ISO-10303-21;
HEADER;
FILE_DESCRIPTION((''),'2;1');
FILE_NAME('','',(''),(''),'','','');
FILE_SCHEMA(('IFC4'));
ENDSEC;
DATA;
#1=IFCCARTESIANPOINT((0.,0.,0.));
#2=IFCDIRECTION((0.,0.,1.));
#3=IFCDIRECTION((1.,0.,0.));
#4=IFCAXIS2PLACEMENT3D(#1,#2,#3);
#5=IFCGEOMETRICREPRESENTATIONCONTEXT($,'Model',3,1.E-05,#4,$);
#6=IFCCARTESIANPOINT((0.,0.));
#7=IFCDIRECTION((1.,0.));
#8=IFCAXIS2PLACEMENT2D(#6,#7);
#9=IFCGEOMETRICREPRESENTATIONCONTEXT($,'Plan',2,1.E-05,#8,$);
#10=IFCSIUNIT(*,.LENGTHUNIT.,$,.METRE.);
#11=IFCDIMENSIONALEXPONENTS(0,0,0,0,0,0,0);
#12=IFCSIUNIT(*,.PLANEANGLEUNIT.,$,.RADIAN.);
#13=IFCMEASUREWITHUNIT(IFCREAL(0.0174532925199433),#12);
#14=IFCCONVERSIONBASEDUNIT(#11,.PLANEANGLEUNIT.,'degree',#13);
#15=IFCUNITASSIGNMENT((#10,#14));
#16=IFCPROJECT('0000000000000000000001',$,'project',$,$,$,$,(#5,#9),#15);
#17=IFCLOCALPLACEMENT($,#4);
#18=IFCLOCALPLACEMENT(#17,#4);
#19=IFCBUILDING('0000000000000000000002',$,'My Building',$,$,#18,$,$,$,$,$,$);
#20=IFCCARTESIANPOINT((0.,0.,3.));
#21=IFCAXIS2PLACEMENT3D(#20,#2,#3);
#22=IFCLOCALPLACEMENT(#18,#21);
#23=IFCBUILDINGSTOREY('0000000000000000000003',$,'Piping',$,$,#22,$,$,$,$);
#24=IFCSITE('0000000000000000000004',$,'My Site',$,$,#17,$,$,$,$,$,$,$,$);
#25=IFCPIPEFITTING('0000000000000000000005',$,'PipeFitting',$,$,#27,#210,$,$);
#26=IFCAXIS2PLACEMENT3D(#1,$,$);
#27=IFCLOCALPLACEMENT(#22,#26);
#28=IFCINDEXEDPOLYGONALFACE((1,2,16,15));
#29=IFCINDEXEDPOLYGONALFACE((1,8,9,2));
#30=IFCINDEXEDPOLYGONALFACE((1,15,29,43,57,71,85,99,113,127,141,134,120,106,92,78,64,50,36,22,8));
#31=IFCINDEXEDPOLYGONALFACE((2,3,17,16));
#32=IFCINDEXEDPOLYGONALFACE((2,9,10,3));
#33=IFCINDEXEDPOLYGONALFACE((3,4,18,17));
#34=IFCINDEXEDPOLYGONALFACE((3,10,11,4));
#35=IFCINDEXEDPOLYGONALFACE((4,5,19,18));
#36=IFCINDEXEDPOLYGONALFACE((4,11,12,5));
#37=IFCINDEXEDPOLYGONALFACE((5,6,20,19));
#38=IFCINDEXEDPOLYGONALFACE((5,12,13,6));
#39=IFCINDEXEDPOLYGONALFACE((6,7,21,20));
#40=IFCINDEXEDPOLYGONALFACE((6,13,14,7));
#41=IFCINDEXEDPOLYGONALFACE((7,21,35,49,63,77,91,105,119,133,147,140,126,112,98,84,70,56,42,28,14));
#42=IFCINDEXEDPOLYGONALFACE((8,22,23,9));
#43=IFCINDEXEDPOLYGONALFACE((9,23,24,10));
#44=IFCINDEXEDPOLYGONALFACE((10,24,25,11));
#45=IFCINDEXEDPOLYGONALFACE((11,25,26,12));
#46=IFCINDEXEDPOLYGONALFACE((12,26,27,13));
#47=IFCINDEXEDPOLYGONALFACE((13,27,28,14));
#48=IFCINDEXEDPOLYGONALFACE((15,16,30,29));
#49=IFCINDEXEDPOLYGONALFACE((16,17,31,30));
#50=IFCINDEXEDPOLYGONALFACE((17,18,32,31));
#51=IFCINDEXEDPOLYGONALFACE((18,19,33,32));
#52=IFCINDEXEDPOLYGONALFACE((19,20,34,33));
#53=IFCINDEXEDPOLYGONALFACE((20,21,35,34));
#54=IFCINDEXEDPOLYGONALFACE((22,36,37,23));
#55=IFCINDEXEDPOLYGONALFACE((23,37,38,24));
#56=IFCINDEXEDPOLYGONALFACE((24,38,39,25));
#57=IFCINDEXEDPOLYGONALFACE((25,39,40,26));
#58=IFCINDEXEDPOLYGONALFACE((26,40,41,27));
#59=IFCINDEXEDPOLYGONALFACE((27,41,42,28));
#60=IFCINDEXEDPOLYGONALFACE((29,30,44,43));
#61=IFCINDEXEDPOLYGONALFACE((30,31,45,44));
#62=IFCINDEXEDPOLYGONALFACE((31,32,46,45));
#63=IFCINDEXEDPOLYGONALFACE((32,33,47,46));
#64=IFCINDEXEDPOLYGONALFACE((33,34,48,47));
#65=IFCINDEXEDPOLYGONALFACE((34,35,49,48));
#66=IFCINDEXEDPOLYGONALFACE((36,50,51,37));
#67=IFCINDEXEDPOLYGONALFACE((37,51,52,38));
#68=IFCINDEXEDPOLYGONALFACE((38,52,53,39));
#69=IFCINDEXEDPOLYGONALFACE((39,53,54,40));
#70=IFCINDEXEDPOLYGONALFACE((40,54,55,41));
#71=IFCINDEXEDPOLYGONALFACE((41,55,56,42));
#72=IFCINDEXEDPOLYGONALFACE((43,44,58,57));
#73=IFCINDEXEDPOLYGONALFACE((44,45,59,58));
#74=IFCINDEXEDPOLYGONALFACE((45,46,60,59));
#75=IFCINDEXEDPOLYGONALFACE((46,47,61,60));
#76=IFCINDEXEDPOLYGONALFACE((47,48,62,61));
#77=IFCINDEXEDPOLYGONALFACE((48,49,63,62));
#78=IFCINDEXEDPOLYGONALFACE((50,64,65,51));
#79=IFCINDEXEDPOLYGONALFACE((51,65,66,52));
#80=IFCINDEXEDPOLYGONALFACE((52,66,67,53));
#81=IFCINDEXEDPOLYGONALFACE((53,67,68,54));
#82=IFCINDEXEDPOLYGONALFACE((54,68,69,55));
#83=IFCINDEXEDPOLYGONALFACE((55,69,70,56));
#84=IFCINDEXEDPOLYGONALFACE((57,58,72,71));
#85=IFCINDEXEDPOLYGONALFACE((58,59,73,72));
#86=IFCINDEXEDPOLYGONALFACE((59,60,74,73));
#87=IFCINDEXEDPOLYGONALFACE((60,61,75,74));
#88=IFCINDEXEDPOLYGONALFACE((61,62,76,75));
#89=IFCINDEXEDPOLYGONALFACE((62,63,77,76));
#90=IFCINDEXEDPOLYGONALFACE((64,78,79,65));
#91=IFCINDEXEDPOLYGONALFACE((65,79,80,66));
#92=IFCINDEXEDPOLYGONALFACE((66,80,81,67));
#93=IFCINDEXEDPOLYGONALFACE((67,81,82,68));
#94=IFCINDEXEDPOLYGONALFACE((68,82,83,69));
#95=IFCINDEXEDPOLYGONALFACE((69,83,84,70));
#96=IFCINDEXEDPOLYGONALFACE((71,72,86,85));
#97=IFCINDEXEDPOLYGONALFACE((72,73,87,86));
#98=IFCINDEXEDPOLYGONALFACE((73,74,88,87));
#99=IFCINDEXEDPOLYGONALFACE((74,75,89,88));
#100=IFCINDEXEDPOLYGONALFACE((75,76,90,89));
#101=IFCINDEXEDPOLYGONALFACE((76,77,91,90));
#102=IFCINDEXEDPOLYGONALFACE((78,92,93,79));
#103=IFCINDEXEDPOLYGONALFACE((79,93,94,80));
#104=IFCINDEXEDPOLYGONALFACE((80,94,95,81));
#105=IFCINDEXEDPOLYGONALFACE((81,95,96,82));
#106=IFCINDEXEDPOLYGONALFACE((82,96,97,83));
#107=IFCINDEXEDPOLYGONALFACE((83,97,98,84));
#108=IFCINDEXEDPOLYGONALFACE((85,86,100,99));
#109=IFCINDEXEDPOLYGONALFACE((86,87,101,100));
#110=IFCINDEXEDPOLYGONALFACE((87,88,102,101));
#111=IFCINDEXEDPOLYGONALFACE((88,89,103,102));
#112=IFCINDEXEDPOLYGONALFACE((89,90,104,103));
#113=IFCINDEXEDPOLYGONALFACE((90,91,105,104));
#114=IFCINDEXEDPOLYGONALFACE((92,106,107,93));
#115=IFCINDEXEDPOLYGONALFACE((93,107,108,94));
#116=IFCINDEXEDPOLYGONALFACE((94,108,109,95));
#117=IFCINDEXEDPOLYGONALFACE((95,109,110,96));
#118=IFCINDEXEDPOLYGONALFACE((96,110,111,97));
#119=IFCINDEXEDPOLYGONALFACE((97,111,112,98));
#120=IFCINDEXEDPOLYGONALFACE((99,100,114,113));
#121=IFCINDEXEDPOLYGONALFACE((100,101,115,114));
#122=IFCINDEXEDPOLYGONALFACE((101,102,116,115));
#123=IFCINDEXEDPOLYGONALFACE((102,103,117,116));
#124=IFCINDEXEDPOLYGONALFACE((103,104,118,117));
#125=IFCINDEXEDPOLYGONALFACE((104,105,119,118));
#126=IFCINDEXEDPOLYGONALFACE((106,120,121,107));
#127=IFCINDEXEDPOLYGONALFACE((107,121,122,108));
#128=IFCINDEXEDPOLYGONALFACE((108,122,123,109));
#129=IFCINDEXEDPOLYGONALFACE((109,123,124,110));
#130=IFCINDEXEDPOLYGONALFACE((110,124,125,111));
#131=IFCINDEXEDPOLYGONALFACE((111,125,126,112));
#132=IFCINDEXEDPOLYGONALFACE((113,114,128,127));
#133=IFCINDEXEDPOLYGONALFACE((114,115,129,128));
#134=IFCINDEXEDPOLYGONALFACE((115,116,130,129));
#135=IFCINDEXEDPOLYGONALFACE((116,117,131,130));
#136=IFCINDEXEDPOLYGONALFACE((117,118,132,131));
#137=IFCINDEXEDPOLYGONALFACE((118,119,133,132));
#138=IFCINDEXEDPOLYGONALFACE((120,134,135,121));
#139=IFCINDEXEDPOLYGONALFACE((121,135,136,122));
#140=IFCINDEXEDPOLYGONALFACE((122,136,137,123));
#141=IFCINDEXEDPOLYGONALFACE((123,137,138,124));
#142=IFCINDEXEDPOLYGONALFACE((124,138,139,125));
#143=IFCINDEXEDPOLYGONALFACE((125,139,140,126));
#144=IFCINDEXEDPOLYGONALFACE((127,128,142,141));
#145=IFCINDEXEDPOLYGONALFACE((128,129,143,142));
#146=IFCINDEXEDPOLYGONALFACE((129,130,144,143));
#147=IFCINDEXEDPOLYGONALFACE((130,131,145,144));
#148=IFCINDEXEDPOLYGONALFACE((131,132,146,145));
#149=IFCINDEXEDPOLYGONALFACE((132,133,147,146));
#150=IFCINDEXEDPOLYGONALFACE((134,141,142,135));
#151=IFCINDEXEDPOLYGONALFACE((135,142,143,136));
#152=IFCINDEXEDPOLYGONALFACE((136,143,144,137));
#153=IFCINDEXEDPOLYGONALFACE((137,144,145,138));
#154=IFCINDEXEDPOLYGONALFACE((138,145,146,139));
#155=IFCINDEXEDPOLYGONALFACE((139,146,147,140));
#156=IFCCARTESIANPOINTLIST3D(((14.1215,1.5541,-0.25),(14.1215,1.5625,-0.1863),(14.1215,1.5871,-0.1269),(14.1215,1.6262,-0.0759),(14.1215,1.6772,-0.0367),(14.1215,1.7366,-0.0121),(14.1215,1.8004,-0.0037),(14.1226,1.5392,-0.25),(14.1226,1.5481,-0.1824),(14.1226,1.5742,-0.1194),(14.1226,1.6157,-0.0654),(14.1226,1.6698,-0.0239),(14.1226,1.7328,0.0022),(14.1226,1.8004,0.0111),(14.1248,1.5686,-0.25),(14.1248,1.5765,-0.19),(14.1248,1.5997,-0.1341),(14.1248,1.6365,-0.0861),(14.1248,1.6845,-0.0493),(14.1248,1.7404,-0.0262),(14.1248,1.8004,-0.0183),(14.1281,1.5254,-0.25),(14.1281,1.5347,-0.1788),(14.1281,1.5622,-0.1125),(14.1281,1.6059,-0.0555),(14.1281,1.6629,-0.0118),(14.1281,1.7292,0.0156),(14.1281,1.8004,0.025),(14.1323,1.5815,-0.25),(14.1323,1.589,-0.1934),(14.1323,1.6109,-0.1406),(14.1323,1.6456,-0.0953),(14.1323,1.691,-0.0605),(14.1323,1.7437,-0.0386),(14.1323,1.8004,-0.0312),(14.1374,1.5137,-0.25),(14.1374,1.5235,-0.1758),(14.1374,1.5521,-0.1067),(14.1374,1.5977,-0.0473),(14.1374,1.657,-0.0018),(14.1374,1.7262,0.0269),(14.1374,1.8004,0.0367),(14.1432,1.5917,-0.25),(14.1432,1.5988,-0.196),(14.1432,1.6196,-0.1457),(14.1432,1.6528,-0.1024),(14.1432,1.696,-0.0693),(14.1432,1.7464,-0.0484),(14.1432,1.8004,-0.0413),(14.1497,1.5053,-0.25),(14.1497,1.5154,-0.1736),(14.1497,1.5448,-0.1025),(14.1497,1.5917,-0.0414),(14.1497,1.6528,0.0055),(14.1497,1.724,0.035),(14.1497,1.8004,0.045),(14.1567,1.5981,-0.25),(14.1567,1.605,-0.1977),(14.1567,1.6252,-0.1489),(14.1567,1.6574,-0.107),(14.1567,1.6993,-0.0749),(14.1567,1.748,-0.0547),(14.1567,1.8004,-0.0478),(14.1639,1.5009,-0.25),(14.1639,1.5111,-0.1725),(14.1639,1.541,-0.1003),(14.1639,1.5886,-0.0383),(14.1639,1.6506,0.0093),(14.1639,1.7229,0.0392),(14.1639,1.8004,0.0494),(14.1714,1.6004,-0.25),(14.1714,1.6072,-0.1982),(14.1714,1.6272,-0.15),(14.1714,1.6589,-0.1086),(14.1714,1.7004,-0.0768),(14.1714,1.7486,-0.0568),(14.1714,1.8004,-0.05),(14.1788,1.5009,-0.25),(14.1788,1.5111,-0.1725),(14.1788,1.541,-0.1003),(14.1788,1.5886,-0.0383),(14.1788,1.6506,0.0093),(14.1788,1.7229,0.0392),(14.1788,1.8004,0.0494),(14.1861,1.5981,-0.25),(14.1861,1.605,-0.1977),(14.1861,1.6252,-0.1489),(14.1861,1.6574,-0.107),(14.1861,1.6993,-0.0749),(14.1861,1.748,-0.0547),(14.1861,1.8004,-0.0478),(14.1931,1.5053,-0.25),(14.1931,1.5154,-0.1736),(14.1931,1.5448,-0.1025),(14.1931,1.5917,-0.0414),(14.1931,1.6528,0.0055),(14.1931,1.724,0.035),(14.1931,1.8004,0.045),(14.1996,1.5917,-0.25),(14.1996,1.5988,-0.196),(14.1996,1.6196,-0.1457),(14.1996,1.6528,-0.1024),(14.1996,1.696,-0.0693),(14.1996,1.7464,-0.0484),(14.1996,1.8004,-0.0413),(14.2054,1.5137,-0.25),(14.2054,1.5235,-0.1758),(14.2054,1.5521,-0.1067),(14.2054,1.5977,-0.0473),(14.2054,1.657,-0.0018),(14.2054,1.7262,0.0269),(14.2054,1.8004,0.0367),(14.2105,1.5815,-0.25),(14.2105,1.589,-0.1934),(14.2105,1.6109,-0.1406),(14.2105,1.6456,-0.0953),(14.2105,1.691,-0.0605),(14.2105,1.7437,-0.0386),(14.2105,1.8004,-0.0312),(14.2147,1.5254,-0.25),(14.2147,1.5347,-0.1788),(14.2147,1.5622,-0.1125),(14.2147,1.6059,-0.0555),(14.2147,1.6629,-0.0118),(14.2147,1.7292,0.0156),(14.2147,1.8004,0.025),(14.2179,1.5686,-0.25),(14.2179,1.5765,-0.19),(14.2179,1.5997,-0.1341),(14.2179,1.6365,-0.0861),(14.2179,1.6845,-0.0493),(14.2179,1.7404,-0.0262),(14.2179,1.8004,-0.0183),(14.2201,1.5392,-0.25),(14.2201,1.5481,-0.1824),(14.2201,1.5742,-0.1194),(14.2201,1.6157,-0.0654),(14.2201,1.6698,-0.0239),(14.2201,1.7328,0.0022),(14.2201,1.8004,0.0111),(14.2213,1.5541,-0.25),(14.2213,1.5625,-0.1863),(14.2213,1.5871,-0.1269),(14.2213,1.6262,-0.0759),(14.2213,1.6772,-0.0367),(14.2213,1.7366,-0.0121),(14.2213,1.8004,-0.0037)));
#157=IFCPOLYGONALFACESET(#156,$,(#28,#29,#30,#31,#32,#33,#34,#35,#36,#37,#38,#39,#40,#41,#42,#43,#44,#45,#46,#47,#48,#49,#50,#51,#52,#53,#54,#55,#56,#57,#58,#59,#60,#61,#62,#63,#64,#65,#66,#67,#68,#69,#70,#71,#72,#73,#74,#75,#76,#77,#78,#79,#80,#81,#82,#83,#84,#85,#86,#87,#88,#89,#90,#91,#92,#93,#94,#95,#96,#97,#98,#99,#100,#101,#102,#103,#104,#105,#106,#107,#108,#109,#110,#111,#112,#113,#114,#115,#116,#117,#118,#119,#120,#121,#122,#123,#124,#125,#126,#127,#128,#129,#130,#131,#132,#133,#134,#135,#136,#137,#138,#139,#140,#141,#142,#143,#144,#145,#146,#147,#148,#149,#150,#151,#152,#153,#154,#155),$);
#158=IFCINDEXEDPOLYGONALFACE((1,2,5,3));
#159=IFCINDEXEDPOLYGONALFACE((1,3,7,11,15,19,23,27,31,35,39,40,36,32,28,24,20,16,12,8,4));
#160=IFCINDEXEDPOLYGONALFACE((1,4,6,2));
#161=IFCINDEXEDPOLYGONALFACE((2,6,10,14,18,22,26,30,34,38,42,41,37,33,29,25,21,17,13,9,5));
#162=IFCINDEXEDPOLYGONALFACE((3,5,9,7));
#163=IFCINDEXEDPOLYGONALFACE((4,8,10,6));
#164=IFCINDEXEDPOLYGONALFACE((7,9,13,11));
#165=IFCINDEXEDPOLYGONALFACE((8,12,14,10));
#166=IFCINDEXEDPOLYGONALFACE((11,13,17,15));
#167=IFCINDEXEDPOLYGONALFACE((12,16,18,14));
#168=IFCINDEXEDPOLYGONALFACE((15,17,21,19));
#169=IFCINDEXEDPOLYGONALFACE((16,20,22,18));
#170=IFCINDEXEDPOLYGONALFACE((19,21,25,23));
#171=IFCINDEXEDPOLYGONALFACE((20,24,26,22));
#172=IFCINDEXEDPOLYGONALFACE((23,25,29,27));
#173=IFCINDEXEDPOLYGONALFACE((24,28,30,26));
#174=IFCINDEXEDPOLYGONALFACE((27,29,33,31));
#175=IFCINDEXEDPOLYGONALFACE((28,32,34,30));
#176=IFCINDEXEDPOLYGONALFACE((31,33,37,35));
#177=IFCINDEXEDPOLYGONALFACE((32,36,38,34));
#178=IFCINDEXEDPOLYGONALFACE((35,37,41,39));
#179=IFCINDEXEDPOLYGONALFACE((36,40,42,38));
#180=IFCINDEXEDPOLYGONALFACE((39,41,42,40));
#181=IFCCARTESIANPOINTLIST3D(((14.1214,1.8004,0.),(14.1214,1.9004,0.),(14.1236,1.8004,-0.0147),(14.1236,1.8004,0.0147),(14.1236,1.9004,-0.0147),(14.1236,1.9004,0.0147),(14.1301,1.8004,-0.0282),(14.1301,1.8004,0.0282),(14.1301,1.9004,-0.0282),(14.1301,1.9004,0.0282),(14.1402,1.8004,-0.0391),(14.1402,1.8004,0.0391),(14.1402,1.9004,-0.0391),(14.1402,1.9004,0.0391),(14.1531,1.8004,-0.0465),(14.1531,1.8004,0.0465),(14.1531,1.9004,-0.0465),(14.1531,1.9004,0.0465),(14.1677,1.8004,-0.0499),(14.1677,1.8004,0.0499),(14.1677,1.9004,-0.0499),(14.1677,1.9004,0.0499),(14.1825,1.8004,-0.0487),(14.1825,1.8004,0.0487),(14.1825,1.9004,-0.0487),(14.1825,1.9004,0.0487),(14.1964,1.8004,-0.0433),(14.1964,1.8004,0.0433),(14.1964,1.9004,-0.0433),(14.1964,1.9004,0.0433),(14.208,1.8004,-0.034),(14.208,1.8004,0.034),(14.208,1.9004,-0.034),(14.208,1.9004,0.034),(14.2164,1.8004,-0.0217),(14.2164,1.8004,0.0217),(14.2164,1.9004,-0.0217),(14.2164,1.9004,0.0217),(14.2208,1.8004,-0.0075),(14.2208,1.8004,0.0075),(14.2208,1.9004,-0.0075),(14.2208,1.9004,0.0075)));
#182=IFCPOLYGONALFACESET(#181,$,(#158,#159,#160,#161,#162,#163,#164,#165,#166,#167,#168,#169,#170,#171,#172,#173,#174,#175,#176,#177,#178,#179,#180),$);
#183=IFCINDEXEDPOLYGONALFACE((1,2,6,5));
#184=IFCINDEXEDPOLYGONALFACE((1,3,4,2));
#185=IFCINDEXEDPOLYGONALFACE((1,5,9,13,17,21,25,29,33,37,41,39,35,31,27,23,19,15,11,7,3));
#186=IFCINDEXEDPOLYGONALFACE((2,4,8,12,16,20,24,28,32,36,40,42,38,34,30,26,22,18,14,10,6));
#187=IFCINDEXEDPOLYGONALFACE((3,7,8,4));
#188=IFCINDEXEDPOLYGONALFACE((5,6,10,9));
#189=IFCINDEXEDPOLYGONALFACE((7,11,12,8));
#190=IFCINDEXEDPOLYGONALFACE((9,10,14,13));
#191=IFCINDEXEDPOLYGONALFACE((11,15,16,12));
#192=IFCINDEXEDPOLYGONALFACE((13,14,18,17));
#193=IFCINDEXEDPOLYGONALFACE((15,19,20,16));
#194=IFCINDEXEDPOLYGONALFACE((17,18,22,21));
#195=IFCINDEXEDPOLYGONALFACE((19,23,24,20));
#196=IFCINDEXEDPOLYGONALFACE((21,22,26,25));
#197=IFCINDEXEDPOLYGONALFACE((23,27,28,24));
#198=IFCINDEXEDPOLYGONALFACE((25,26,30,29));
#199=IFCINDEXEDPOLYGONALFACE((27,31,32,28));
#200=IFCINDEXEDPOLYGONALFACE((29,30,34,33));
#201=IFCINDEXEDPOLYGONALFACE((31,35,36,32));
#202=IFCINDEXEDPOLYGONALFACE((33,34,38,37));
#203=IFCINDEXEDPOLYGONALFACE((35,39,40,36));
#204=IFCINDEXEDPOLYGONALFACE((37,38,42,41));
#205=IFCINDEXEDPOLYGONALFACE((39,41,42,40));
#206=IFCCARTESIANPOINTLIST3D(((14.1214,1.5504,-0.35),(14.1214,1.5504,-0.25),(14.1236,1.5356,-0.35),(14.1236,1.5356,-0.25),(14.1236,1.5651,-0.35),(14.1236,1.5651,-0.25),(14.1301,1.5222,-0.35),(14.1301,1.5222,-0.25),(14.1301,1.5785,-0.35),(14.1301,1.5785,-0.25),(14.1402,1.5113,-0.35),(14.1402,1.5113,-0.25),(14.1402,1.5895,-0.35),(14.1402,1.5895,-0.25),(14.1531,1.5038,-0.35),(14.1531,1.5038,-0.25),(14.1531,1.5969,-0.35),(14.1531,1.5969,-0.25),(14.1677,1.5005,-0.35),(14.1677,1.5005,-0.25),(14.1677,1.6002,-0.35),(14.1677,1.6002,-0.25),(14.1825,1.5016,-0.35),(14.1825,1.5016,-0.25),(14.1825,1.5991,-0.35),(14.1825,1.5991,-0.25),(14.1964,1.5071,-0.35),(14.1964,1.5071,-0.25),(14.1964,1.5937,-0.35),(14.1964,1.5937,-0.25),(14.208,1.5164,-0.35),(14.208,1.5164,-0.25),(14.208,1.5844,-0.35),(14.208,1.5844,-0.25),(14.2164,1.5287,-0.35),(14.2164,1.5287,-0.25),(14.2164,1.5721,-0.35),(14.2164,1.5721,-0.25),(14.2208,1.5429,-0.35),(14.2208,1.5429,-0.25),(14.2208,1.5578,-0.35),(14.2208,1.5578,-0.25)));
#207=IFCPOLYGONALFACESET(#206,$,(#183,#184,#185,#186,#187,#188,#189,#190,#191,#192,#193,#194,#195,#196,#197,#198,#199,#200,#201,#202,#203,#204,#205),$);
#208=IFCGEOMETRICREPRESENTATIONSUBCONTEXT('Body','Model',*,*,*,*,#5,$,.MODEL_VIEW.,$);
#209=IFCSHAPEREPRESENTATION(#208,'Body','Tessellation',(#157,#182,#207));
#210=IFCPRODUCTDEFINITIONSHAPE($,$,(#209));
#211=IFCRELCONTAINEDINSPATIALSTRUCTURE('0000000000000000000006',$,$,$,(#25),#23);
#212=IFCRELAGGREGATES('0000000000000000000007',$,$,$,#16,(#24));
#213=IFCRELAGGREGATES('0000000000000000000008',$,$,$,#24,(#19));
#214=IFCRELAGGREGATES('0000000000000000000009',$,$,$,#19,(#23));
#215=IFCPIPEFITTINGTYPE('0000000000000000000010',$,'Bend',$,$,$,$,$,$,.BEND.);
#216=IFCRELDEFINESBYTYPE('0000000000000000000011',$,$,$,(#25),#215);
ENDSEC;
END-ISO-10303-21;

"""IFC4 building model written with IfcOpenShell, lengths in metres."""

from ifc_helpers import new_model, entity, si_unit, converted_unit, frame, origin_with_axes, origin_2d_with_axis, place, context, subcontext, project, spatial, circle, extrude, source, transform, mapped, type_object, type_shapes, element, save


model = new_model("IFC4")

# Units and contexts
model_context = context("Model", 3, precision=1e-05, world=origin_with_axes())
plan_context = context("Plan", 2, precision=1e-05, world=origin_2d_with_axis())
body_context = subcontext(model_context, "Body", "Model", "MODEL_VIEW")
ifc_project = project(units=[si_unit("LENGTHUNIT", "METRE"), converted_unit("PLANEANGLEUNIT", "degree", entity("IfcReal", 0.0174532925199433), si_unit("PLANEANGLEUNIT", "RADIAN"), dimensions=[0, 0, 0, 0, 0, 0, 0])], contexts=[model_context, plan_context])

# Site, building, storey
site_placement = place(None, origin_with_axes())
site = spatial("IfcSite", under=ifc_project, at=site_placement, Name="My Site")
building_placement = place(site_placement, origin_with_axes())
building = spatial("IfcBuilding", under=site, at=building_placement, Name="My Building")
storey_placement = place(building_placement, frame((0.0, 0.0, 3.0), z_axis=(0.0, 0.0, 1.0), x_axis=(1.0, 0.0, 0.0)))
storey = spatial("IfcBuildingStorey", under=building, at=storey_placement, Name="Piping")

# Pipe fitting
pipe_fitting_type = type_object("IfcPipeFittingType", Name="Bend", PredefinedType="BEND")
shared_shape = source(origin_with_axes(), body_context, "Body", "SolidModel", [
    entity("IfcSweptDiskSolid", entity("IfcIndexedPolyCurve", entity("IfcCartesianPointList3D", [[0.0, 0.0, -0.1], [0.0, -0.0732, -0.2768], [0.0, -0.25, -0.35]]), [entity("IfcArcIndex", [1, 2, 3])]), 0.05),
    extrude(circle(Radius=0.05), origin_with_axes(), (0.0, 0.0, -1.0), 0.1),
    extrude(circle(Radius=0.05), frame((0.0, -0.25, -0.35), z_axis=(0.0, -1.0, 0.0), x_axis=(1.0, 0.0, 0.0)), (0.0, 0.0, 1.0), 0.1),
])
type_shapes(pipe_fitting_type, [shared_shape])
for number, where, z_axis, x_axis, name in (
    (1, (14.1714, 1.9004, 0.0), (0.0, 1.0, 0.0), (-1.0, 0.0, 0.0), "PipeFitting"),
):
    element("IfcPipeFitting", number, at=place(storey_placement, frame(where, z_axis=z_axis, x_axis=x_axis)), inside=storey, type_object=pipe_fitting_type, Name=name, context=body_context, shape_type="MappedRepresentation", body=[
        mapped(shared_shape, transform((0.0, 0.0, 0.0), x_axis=(1.0, 0.0, 0.0), y_axis=(0.0, 1.0, 0.0), z_axis=(0.0, 0.0, 1.0), scale=1.0)),
    ])

save(model, "model.ifc")
